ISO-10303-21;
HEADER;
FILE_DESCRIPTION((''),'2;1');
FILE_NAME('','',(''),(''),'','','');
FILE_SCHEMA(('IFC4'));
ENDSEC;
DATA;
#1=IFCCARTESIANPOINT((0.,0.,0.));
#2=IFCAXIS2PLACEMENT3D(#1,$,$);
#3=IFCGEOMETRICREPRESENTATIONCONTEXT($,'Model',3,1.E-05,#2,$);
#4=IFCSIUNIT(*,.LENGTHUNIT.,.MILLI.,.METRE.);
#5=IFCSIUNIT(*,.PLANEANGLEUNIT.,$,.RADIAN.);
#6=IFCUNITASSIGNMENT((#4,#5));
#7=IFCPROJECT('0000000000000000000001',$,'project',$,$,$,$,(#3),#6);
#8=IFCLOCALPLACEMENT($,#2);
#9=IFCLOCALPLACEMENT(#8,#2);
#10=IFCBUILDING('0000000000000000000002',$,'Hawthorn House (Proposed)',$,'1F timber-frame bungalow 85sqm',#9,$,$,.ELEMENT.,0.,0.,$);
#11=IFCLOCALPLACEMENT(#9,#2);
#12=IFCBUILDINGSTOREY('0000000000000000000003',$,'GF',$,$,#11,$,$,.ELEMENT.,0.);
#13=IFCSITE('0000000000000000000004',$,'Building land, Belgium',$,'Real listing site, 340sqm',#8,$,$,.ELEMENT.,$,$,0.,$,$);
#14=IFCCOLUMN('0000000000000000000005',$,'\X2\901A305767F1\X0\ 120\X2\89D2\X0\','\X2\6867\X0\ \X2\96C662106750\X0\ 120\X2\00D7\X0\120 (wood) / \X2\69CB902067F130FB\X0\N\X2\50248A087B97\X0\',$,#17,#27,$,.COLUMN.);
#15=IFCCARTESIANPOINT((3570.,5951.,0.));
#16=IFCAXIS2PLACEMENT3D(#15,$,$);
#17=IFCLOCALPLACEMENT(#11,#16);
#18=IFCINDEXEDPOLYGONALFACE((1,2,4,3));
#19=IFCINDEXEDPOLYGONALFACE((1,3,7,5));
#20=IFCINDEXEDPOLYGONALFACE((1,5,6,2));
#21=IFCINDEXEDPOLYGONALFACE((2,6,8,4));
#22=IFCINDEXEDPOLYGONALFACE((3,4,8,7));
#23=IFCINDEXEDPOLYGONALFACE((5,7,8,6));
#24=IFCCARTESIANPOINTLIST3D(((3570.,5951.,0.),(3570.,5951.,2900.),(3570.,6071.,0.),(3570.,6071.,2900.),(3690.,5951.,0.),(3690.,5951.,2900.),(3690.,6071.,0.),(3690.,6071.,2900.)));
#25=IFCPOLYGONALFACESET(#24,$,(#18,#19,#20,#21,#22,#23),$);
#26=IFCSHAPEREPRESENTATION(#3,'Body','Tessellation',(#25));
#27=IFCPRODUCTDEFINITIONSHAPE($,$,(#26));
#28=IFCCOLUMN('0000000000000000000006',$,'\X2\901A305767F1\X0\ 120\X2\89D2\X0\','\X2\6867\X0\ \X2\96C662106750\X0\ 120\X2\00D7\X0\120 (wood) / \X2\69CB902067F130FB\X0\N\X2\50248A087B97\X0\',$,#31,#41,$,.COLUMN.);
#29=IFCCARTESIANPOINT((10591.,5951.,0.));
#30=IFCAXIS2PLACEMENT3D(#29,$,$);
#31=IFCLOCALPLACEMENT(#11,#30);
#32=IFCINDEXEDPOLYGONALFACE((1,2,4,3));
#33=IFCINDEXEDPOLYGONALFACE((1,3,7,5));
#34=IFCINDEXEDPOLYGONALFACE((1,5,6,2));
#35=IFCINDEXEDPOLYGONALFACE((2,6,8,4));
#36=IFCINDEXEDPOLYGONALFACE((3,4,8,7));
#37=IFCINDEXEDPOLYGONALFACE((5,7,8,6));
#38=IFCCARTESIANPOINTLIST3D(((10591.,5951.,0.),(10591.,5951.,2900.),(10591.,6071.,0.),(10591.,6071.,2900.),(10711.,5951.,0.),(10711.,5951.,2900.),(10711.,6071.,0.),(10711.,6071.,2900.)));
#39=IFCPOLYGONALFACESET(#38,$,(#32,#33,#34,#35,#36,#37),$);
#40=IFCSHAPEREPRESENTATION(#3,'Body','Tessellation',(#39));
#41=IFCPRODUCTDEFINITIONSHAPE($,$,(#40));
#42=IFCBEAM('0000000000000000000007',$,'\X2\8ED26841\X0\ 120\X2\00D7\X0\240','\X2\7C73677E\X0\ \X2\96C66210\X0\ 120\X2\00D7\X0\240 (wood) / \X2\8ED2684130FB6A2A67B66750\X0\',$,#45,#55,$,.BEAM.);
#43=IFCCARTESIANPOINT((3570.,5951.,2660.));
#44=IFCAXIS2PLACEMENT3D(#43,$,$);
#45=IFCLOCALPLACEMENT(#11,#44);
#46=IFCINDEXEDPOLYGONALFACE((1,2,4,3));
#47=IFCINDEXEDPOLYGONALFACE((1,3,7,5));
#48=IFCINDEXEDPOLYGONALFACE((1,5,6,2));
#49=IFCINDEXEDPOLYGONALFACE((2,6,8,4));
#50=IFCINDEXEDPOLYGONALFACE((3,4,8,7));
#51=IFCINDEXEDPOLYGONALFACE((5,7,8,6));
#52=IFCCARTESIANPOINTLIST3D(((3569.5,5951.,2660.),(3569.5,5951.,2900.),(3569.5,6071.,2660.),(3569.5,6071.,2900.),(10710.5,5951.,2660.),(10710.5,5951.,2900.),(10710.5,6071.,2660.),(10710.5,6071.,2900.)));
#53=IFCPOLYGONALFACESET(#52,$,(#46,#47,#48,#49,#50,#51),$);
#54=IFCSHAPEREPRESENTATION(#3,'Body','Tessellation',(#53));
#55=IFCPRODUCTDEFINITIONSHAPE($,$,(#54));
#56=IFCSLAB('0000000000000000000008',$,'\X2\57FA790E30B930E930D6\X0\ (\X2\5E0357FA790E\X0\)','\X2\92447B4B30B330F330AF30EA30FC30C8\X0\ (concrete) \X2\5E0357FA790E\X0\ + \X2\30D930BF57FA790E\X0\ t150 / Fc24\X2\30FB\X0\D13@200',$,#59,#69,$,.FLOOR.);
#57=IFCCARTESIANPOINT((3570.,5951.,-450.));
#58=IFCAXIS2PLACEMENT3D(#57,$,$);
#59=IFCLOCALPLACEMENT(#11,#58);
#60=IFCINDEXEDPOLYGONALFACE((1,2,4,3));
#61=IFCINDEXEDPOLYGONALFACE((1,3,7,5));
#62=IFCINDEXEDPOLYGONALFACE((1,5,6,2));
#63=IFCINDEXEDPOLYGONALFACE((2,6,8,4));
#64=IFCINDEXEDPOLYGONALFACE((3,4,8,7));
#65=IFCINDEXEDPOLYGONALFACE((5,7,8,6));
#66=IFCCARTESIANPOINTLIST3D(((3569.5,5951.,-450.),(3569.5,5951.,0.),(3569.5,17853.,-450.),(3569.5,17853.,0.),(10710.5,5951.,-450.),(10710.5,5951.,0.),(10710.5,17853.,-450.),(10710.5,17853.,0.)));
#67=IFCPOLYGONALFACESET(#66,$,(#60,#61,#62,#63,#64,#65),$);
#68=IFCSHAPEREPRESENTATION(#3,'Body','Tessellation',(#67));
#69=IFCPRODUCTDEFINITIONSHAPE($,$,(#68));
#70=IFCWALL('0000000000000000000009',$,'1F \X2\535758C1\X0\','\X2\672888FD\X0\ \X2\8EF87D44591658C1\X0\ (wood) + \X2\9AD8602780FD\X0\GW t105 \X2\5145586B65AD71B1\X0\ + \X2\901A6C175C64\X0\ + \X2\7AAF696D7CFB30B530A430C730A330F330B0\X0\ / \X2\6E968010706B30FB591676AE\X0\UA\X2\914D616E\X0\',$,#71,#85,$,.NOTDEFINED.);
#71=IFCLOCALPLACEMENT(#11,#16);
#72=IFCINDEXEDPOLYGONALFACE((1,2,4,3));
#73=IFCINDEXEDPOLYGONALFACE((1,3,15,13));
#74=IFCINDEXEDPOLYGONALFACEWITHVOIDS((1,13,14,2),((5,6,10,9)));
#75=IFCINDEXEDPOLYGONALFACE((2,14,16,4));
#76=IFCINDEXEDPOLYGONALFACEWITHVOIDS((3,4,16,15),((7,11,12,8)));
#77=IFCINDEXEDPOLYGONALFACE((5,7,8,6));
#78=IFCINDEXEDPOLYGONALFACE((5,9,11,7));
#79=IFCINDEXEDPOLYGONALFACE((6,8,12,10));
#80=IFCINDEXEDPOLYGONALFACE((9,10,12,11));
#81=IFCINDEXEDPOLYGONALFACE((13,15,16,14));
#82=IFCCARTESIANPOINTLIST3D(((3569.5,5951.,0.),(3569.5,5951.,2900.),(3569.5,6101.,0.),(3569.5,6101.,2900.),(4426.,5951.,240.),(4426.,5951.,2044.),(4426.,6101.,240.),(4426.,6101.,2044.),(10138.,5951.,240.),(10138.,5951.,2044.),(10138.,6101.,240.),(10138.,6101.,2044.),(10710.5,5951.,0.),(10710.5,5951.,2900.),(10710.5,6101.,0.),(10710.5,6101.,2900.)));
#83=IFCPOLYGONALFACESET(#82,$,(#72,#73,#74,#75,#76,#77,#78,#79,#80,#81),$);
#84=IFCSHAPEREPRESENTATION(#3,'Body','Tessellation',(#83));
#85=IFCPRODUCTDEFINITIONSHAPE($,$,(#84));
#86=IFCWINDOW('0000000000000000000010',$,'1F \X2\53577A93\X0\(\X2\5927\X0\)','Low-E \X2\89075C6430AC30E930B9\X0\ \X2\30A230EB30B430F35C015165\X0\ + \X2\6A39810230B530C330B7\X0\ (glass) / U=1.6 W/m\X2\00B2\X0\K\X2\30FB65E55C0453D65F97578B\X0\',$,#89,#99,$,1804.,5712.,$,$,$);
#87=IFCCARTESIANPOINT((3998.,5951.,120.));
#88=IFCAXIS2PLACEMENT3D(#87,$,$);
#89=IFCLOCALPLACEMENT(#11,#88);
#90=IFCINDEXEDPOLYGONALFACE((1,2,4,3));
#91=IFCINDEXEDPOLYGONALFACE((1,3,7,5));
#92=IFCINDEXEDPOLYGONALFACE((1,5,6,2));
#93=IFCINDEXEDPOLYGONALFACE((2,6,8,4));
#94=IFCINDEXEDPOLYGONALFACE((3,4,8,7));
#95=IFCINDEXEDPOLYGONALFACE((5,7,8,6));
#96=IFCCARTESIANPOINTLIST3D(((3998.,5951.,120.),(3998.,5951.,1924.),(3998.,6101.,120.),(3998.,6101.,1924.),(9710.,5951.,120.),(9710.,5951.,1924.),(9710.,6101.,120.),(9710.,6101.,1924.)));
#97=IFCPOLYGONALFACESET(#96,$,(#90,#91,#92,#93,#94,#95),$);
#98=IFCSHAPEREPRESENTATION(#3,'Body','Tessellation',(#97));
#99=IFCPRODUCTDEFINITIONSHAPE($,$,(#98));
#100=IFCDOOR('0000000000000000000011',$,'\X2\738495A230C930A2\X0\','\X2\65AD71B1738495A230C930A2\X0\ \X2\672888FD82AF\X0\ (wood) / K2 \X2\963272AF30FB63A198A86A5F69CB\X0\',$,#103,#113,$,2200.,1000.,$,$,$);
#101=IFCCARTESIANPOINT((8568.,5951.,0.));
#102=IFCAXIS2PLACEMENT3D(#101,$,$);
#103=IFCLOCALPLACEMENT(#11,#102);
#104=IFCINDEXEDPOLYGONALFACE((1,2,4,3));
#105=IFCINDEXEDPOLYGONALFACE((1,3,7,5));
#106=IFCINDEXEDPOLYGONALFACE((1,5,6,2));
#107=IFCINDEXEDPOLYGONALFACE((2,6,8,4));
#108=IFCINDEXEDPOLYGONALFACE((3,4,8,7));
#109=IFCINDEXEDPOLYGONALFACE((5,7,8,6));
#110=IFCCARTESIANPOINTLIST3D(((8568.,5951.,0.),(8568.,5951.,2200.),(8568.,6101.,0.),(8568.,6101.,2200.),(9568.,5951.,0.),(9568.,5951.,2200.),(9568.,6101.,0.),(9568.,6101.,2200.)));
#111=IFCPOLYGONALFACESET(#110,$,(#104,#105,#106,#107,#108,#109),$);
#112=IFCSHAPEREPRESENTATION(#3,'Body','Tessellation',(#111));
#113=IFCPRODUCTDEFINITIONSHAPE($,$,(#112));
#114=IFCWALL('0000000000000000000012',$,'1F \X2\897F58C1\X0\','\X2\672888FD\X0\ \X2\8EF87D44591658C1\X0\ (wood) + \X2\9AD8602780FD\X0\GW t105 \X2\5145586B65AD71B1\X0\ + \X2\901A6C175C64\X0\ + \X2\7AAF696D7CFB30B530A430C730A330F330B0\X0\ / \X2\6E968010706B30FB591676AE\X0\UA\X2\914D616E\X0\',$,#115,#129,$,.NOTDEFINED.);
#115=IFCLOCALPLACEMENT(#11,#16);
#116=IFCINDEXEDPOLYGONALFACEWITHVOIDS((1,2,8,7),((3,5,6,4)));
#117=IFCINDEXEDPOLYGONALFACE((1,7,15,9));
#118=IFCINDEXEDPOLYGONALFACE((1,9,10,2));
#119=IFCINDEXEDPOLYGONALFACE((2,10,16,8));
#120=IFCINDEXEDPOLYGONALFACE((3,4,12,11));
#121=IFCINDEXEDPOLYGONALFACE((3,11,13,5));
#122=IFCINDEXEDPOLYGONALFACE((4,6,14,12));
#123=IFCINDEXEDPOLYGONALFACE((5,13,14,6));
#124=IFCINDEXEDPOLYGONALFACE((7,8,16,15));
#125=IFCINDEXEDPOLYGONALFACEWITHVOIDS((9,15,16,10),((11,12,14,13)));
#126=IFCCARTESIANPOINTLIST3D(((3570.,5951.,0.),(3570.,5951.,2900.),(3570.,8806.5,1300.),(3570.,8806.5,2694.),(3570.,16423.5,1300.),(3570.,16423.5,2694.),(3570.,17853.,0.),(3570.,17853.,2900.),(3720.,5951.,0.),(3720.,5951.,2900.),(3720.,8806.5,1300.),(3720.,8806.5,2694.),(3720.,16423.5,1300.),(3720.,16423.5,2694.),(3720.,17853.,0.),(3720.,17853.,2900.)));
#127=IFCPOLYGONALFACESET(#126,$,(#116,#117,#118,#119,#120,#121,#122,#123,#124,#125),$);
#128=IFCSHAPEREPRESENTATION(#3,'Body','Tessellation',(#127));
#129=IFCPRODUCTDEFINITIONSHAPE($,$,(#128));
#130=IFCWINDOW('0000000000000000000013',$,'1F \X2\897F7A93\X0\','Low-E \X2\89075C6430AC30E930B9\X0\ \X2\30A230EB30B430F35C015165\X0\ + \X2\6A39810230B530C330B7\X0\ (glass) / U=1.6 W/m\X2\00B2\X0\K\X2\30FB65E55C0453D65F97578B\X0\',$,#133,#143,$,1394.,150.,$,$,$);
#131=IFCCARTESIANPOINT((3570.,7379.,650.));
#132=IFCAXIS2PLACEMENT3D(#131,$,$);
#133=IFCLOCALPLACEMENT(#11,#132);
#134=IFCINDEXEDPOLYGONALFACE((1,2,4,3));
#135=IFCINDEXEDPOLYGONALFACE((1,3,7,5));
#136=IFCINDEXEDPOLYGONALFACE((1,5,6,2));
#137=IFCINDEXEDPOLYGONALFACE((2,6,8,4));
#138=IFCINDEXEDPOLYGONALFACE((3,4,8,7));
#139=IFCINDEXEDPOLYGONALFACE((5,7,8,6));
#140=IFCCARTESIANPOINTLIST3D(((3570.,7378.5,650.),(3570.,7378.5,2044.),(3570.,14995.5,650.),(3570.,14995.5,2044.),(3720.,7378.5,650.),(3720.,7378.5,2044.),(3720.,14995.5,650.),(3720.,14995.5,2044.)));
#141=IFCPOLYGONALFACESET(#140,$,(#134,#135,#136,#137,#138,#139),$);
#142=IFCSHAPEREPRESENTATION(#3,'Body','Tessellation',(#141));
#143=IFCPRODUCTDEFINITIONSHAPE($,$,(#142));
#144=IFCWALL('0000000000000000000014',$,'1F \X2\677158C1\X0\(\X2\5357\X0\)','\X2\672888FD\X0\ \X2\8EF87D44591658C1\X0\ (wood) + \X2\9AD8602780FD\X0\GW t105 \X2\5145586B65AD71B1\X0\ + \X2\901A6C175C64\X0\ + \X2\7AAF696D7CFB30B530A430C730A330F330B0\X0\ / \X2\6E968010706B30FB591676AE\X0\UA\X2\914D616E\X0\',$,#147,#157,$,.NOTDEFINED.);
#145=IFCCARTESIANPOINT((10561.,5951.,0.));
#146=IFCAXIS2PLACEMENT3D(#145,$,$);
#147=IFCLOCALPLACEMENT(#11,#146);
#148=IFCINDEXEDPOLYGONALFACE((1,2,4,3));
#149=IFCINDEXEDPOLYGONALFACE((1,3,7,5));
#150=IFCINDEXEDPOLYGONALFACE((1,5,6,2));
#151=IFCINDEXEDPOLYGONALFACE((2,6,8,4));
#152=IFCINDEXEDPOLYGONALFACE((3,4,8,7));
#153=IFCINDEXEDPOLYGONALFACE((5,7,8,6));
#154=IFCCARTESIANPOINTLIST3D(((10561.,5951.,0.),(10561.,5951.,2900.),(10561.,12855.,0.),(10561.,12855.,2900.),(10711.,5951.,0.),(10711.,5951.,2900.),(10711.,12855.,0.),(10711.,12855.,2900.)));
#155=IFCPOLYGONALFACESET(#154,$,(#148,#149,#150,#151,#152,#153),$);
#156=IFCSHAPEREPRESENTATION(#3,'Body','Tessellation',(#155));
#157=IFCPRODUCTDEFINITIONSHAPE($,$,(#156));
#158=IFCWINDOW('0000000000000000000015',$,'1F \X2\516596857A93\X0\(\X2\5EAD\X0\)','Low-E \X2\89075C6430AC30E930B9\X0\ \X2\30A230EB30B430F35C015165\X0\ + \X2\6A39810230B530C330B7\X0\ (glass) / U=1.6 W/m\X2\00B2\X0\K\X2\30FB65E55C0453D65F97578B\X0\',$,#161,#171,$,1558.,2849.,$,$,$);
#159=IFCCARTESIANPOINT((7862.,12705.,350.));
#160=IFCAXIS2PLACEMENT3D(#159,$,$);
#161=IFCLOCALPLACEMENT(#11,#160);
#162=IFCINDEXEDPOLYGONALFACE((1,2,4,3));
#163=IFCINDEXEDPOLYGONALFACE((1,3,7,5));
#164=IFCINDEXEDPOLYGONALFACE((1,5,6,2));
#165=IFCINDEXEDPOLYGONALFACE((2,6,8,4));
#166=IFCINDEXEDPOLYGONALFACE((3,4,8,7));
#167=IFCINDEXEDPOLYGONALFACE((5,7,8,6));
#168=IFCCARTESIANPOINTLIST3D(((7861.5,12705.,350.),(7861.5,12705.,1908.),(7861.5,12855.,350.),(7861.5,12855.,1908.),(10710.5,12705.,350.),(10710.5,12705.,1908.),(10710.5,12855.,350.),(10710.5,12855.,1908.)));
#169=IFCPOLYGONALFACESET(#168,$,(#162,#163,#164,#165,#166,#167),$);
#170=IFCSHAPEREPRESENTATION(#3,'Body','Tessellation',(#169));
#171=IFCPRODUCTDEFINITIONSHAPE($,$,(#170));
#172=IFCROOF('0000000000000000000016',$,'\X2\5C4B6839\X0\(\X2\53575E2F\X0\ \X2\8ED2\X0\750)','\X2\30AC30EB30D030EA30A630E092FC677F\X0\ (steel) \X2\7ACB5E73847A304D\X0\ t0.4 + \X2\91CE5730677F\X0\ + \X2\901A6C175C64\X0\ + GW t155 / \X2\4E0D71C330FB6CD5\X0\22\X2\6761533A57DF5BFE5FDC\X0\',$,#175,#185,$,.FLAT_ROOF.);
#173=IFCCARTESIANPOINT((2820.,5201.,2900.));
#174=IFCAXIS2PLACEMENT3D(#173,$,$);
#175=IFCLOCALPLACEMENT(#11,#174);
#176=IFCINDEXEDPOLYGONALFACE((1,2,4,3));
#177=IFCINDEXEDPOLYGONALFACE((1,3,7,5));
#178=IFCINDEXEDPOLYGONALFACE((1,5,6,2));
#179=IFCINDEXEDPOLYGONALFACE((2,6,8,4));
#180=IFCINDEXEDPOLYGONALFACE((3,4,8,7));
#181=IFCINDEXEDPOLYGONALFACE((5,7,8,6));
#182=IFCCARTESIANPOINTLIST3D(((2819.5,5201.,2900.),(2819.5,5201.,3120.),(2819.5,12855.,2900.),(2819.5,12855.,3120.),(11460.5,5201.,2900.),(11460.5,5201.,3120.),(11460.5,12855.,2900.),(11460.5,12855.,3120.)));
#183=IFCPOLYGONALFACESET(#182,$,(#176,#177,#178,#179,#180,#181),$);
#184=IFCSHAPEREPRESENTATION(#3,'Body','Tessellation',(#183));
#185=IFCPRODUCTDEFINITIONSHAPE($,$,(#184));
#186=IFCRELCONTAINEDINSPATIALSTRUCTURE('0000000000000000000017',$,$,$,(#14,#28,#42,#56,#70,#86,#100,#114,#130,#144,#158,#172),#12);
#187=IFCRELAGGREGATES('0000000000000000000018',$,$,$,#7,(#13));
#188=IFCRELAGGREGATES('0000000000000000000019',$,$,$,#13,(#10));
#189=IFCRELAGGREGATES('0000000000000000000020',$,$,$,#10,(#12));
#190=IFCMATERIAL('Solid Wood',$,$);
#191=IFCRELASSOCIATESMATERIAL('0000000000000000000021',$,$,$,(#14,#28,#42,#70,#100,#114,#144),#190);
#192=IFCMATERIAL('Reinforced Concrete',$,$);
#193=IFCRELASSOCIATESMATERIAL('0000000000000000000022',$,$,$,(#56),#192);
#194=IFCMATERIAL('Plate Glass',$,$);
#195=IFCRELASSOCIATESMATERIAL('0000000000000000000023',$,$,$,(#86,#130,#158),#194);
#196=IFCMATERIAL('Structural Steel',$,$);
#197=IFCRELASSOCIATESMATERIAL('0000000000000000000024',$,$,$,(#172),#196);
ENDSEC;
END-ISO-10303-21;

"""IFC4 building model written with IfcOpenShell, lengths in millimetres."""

from ifc_helpers import new_model, si_unit, frame, frame_2d, origin, place, context, project, spatial, rectangle, extrude, material, element, fill, save


model = new_model("IFC4")

# Units and contexts
model_context = context("Model", 3, precision=1e-05, world=origin())
ifc_project = project(units=[si_unit("LENGTHUNIT", "METRE", prefix="MILLI"), si_unit("PLANEANGLEUNIT", "RADIAN")], contexts=[model_context])

# Site, building, storey
site_placement = place(None, origin())
site = spatial("IfcSite", under=ifc_project, at=site_placement, Name="Building land, Belgium", ObjectType="Real listing site, 340sqm", CompositionType="ELEMENT", RefElevation=0.0)
building_placement = place(site_placement, origin())
building = spatial("IfcBuilding", under=site, at=building_placement, Name="Hawthorn House (Proposed)", ObjectType="1F timber-frame bungalow 85sqm", CompositionType="ELEMENT", ElevationOfRefHeight=0.0, ElevationOfTerrain=0.0)
storey_placement = place(building_placement, origin())
storey = spatial("IfcBuildingStorey", under=building, at=storey_placement, Name="GF", CompositionType="ELEMENT", Elevation=0.0)

# Columns
ifc_material_1 = material(Name="Solid Wood")
column_1_placement = place(storey_placement, frame((3570.0, 5951.0, 0.0)))
element("IfcColumn", 1, at=column_1_placement, inside=storey, material=ifc_material_1, Name="通し柱 120角", Description="桧 集成材 120×120 (wood) / 構造柱・N値計算", PredefinedType="COLUMN", context=model_context, shape_type="SweptSolid", body=[
    extrude(rectangle(XDim=120.0, YDim=120.0, at=frame_2d((60.0, 60.0))), frame((3570.0, 5951.0, 0.0)), (0.0, 0.0, 1.0), 2900.0),
])
column_2_placement = place(storey_placement, frame((10591.0, 5951.0, 0.0)))
element("IfcColumn", 2, at=column_2_placement, inside=storey, material=ifc_material_1, Name="通し柱 120角", Description="桧 集成材 120×120 (wood) / 構造柱・N値計算", PredefinedType="COLUMN", context=model_context, shape_type="SweptSolid", body=[
    extrude(rectangle(XDim=120.0, YDim=120.0, at=frame_2d((60.0, 60.0))), frame((10591.0, 5951.0, 0.0)), (0.0, 0.0, 1.0), 2900.0),
])

# Beam
beam_1_placement = place(storey_placement, frame((3570.0, 5951.0, 2660.0)))
element("IfcBeam", 3, at=beam_1_placement, inside=storey, material=ifc_material_1, Name="軒桁 120×240", Description="米松 集成 120×240 (wood) / 軒桁・横架材", PredefinedType="BEAM", context=model_context, shape_type="SweptSolid", body=[
    extrude(rectangle(XDim=7141.0, YDim=120.0, at=frame_2d((3570.0, 60.0))), frame((3570.0, 5951.0, 2660.0)), (0.0, 0.0, 1.0), 240.0),
])

# Slab
ifc_material_2 = material(Name="Reinforced Concrete")
slab_1_placement = place(storey_placement, frame((3570.0, 5951.0, -450.0)))
element("IfcSlab", 4, at=slab_1_placement, inside=storey, material=ifc_material_2, Name="基礎スラブ (布基礎)", Description="鉄筋コンクリート (concrete) 布基礎 + ベタ基礎 t150 / Fc24・D13@200", PredefinedType="FLOOR", context=model_context, shape_type="SweptSolid", body=[
    extrude(rectangle(XDim=7141.0, YDim=11902.0, at=frame_2d((3570.0, 5951.0))), frame((3570.0, 5951.0, -450.0)), (0.0, 0.0, 1.0), 450.0),
])

# Wall, openings, window, door
wall_1_placement = place(storey_placement, frame((3570.0, 5951.0, 0.0)))
wall_1 = element("IfcWall", 5, at=wall_1_placement, inside=storey, material=ifc_material_1, Name="1F 南壁", Description="木製 軸組外壁 (wood) + 高性能GW t105 充填断熱 + 通気層 + 窯業系サイディング / 準耐火・外皮UA配慮", PredefinedType="NOTDEFINED", context=model_context, shape_type="SweptSolid", body=[
    extrude(rectangle(XDim=7141.0, YDim=150.0, at=frame_2d((3570.0, 75.0))), frame((3570.0, 5951.0, 0.0)), (0.0, 0.0, 1.0), 2900.0),
])
opening_1_placement = place(storey_placement, frame((3998.0, 5951.0, 120.0)))
opening_1 = element("IfcOpeningElement", 6, at=opening_1_placement, cuts=wall_1, PredefinedType="NOTDEFINED", context=model_context, shape_type="SweptSolid", body=[
    extrude(rectangle(XDim=5712.0, YDim=150.0, at=frame_2d((2856.0, 75.0))), frame((3998.0, 5951.0, 120.0)), (0.0, 0.0, 1.0), 1804.0),
])
opening_2_placement = place(storey_placement, frame((8568.0, 5951.0, 0.0)))
opening_2 = element("IfcOpeningElement", 7, at=opening_2_placement, cuts=wall_1, PredefinedType="NOTDEFINED", context=model_context, shape_type="SweptSolid", body=[
    extrude(rectangle(XDim=1000.0, YDim=150.0, at=frame_2d((500.0, 75.0))), frame((8568.0, 5951.0, 0.0)), (0.0, 0.0, 1.0), 2200.0),
])
ifc_material_3 = material(Name="Plate Glass")
window_1_placement = place(storey_placement, frame((3998.0, 5951.0, 120.0)))
window_1 = element("IfcWindow", 8, at=window_1_placement, inside=storey, material=ifc_material_3, Name="1F 南窓(大)", Description="Low-E 複層ガラス アルゴン封入 + 樹脂サッシ (glass) / U=1.6 W/m²K・日射取得型", OverallHeight=1804.0, OverallWidth=5712.0, context=model_context, shape_type="SweptSolid", body=[
    extrude(rectangle(XDim=5712.0, YDim=150.0, at=frame_2d((2856.0, 75.0))), frame((3998.0, 5951.0, 120.0)), (0.0, 0.0, 1.0), 1804.0),
])
fill(opening_1, window_1)
door_1_placement = place(storey_placement, frame((8568.0, 5951.0, 0.0)))
door_1 = element("IfcDoor", 9, at=door_1_placement, inside=storey, material=ifc_material_1, Name="玄関ドア", Description="断熱玄関ドア 木製芯 (wood) / K2 防犯・採風機構", OverallHeight=2200.0, OverallWidth=1000.0, context=model_context, shape_type="SweptSolid", body=[
    extrude(rectangle(XDim=1000.0, YDim=150.0, at=frame_2d((500.0, 75.0))), frame((8568.0, 5951.0, 0.0)), (0.0, 0.0, 1.0), 2200.0),
])
fill(opening_2, door_1)

# Walls, openings, windows
wall_2_placement = place(storey_placement, frame((3570.0, 5951.0, 0.0)))
wall_2 = element("IfcWall", 10, at=wall_2_placement, inside=storey, material=ifc_material_1, Name="1F 西壁", Description="木製 軸組外壁 (wood) + 高性能GW t105 充填断熱 + 通気層 + 窯業系サイディング / 準耐火・外皮UA配慮", PredefinedType="NOTDEFINED", context=model_context, shape_type="SweptSolid", body=[
    extrude(rectangle(XDim=150.0, YDim=11902.0, at=frame_2d((75.0, 5951.0))), frame((3570.0, 5951.0, 0.0)), (0.0, 0.0, 1.0), 2900.0),
])
opening_3_placement = place(storey_placement, frame((3570.0, 7379.0, 650.0)))
opening_3 = element("IfcOpeningElement", 11, at=opening_3_placement, cuts=wall_2, PredefinedType="NOTDEFINED", context=model_context, shape_type="SweptSolid", body=[
    extrude(rectangle(XDim=150.0, YDim=7617.0, at=frame_2d((75.0, 3808.0))), frame((3570.0, 7379.0, 650.0)), (0.0, 0.0, 1.0), 1394.0),
])
window_2_placement = place(storey_placement, frame((3570.0, 7379.0, 650.0)))
window_2 = element("IfcWindow", 12, at=window_2_placement, inside=storey, material=ifc_material_3, Name="1F 西窓", Description="Low-E 複層ガラス アルゴン封入 + 樹脂サッシ (glass) / U=1.6 W/m²K・日射取得型", OverallHeight=1394.0, OverallWidth=150.0, context=model_context, shape_type="SweptSolid", body=[
    extrude(rectangle(XDim=150.0, YDim=7617.0, at=frame_2d((75.0, 3808.0))), frame((3570.0, 7379.0, 650.0)), (0.0, 0.0, 1.0), 1394.0),
])
fill(opening_3, window_2)
wall_3_placement = place(storey_placement, frame((10561.0, 5951.0, 0.0)))
wall_3 = element("IfcWall", 13, at=wall_3_placement, inside=storey, material=ifc_material_1, Name="1F 東壁(南)", Description="木製 軸組外壁 (wood) + 高性能GW t105 充填断熱 + 通気層 + 窯業系サイディング / 準耐火・外皮UA配慮", PredefinedType="NOTDEFINED", context=model_context, shape_type="SweptSolid", body=[
    extrude(rectangle(XDim=150.0, YDim=6904.0, at=frame_2d((75.0, 3452.0))), frame((10561.0, 5951.0, 0.0)), (0.0, 0.0, 1.0), 2900.0),
])
opening_4_placement = place(storey_placement, frame((7862.0, 12705.0, 350.0)))
opening_4 = element("IfcOpeningElement", 14, at=opening_4_placement, cuts=wall_3, PredefinedType="NOTDEFINED", context=model_context, shape_type="SweptSolid", body=[
    extrude(rectangle(XDim=2849.0, YDim=150.0, at=frame_2d((1424.0, 75.0))), frame((7862.0, 12705.0, 350.0)), (0.0, 0.0, 1.0), 1558.0),
])
window_3_placement = place(storey_placement, frame((7862.0, 12705.0, 350.0)))
window_3 = element("IfcWindow", 15, at=window_3_placement, inside=storey, material=ifc_material_3, Name="1F 入隅窓(庭)", Description="Low-E 複層ガラス アルゴン封入 + 樹脂サッシ (glass) / U=1.6 W/m²K・日射取得型", OverallHeight=1558.0, OverallWidth=2849.0, context=model_context, shape_type="SweptSolid", body=[
    extrude(rectangle(XDim=2849.0, YDim=150.0, at=frame_2d((1424.0, 75.0))), frame((7862.0, 12705.0, 350.0)), (0.0, 0.0, 1.0), 1558.0),
])
fill(opening_4, window_3)

# Roof
ifc_material_4 = material(Name="Structural Steel")
roof_placement = place(storey_placement, frame((2820.0, 5201.0, 2900.0)))
element("IfcRoof", 16, at=roof_placement, inside=storey, material=ifc_material_4, Name="屋根(南帯 軒750)", Description="ガルバリウム鋼板 (steel) 立平葺き t0.4 + 野地板 + 通気層 + GW t155 / 不燃・法22条区域対応", PredefinedType="FLAT_ROOF", context=model_context, shape_type="SweptSolid", body=[
    extrude(rectangle(XDim=8641.0, YDim=7654.0, at=frame_2d((4320.0, 3827.0))), frame((2820.0, 5201.0, 2900.0)), (0.0, 0.0, 1.0), 220.0),
])

save(model, "model.ifc")
